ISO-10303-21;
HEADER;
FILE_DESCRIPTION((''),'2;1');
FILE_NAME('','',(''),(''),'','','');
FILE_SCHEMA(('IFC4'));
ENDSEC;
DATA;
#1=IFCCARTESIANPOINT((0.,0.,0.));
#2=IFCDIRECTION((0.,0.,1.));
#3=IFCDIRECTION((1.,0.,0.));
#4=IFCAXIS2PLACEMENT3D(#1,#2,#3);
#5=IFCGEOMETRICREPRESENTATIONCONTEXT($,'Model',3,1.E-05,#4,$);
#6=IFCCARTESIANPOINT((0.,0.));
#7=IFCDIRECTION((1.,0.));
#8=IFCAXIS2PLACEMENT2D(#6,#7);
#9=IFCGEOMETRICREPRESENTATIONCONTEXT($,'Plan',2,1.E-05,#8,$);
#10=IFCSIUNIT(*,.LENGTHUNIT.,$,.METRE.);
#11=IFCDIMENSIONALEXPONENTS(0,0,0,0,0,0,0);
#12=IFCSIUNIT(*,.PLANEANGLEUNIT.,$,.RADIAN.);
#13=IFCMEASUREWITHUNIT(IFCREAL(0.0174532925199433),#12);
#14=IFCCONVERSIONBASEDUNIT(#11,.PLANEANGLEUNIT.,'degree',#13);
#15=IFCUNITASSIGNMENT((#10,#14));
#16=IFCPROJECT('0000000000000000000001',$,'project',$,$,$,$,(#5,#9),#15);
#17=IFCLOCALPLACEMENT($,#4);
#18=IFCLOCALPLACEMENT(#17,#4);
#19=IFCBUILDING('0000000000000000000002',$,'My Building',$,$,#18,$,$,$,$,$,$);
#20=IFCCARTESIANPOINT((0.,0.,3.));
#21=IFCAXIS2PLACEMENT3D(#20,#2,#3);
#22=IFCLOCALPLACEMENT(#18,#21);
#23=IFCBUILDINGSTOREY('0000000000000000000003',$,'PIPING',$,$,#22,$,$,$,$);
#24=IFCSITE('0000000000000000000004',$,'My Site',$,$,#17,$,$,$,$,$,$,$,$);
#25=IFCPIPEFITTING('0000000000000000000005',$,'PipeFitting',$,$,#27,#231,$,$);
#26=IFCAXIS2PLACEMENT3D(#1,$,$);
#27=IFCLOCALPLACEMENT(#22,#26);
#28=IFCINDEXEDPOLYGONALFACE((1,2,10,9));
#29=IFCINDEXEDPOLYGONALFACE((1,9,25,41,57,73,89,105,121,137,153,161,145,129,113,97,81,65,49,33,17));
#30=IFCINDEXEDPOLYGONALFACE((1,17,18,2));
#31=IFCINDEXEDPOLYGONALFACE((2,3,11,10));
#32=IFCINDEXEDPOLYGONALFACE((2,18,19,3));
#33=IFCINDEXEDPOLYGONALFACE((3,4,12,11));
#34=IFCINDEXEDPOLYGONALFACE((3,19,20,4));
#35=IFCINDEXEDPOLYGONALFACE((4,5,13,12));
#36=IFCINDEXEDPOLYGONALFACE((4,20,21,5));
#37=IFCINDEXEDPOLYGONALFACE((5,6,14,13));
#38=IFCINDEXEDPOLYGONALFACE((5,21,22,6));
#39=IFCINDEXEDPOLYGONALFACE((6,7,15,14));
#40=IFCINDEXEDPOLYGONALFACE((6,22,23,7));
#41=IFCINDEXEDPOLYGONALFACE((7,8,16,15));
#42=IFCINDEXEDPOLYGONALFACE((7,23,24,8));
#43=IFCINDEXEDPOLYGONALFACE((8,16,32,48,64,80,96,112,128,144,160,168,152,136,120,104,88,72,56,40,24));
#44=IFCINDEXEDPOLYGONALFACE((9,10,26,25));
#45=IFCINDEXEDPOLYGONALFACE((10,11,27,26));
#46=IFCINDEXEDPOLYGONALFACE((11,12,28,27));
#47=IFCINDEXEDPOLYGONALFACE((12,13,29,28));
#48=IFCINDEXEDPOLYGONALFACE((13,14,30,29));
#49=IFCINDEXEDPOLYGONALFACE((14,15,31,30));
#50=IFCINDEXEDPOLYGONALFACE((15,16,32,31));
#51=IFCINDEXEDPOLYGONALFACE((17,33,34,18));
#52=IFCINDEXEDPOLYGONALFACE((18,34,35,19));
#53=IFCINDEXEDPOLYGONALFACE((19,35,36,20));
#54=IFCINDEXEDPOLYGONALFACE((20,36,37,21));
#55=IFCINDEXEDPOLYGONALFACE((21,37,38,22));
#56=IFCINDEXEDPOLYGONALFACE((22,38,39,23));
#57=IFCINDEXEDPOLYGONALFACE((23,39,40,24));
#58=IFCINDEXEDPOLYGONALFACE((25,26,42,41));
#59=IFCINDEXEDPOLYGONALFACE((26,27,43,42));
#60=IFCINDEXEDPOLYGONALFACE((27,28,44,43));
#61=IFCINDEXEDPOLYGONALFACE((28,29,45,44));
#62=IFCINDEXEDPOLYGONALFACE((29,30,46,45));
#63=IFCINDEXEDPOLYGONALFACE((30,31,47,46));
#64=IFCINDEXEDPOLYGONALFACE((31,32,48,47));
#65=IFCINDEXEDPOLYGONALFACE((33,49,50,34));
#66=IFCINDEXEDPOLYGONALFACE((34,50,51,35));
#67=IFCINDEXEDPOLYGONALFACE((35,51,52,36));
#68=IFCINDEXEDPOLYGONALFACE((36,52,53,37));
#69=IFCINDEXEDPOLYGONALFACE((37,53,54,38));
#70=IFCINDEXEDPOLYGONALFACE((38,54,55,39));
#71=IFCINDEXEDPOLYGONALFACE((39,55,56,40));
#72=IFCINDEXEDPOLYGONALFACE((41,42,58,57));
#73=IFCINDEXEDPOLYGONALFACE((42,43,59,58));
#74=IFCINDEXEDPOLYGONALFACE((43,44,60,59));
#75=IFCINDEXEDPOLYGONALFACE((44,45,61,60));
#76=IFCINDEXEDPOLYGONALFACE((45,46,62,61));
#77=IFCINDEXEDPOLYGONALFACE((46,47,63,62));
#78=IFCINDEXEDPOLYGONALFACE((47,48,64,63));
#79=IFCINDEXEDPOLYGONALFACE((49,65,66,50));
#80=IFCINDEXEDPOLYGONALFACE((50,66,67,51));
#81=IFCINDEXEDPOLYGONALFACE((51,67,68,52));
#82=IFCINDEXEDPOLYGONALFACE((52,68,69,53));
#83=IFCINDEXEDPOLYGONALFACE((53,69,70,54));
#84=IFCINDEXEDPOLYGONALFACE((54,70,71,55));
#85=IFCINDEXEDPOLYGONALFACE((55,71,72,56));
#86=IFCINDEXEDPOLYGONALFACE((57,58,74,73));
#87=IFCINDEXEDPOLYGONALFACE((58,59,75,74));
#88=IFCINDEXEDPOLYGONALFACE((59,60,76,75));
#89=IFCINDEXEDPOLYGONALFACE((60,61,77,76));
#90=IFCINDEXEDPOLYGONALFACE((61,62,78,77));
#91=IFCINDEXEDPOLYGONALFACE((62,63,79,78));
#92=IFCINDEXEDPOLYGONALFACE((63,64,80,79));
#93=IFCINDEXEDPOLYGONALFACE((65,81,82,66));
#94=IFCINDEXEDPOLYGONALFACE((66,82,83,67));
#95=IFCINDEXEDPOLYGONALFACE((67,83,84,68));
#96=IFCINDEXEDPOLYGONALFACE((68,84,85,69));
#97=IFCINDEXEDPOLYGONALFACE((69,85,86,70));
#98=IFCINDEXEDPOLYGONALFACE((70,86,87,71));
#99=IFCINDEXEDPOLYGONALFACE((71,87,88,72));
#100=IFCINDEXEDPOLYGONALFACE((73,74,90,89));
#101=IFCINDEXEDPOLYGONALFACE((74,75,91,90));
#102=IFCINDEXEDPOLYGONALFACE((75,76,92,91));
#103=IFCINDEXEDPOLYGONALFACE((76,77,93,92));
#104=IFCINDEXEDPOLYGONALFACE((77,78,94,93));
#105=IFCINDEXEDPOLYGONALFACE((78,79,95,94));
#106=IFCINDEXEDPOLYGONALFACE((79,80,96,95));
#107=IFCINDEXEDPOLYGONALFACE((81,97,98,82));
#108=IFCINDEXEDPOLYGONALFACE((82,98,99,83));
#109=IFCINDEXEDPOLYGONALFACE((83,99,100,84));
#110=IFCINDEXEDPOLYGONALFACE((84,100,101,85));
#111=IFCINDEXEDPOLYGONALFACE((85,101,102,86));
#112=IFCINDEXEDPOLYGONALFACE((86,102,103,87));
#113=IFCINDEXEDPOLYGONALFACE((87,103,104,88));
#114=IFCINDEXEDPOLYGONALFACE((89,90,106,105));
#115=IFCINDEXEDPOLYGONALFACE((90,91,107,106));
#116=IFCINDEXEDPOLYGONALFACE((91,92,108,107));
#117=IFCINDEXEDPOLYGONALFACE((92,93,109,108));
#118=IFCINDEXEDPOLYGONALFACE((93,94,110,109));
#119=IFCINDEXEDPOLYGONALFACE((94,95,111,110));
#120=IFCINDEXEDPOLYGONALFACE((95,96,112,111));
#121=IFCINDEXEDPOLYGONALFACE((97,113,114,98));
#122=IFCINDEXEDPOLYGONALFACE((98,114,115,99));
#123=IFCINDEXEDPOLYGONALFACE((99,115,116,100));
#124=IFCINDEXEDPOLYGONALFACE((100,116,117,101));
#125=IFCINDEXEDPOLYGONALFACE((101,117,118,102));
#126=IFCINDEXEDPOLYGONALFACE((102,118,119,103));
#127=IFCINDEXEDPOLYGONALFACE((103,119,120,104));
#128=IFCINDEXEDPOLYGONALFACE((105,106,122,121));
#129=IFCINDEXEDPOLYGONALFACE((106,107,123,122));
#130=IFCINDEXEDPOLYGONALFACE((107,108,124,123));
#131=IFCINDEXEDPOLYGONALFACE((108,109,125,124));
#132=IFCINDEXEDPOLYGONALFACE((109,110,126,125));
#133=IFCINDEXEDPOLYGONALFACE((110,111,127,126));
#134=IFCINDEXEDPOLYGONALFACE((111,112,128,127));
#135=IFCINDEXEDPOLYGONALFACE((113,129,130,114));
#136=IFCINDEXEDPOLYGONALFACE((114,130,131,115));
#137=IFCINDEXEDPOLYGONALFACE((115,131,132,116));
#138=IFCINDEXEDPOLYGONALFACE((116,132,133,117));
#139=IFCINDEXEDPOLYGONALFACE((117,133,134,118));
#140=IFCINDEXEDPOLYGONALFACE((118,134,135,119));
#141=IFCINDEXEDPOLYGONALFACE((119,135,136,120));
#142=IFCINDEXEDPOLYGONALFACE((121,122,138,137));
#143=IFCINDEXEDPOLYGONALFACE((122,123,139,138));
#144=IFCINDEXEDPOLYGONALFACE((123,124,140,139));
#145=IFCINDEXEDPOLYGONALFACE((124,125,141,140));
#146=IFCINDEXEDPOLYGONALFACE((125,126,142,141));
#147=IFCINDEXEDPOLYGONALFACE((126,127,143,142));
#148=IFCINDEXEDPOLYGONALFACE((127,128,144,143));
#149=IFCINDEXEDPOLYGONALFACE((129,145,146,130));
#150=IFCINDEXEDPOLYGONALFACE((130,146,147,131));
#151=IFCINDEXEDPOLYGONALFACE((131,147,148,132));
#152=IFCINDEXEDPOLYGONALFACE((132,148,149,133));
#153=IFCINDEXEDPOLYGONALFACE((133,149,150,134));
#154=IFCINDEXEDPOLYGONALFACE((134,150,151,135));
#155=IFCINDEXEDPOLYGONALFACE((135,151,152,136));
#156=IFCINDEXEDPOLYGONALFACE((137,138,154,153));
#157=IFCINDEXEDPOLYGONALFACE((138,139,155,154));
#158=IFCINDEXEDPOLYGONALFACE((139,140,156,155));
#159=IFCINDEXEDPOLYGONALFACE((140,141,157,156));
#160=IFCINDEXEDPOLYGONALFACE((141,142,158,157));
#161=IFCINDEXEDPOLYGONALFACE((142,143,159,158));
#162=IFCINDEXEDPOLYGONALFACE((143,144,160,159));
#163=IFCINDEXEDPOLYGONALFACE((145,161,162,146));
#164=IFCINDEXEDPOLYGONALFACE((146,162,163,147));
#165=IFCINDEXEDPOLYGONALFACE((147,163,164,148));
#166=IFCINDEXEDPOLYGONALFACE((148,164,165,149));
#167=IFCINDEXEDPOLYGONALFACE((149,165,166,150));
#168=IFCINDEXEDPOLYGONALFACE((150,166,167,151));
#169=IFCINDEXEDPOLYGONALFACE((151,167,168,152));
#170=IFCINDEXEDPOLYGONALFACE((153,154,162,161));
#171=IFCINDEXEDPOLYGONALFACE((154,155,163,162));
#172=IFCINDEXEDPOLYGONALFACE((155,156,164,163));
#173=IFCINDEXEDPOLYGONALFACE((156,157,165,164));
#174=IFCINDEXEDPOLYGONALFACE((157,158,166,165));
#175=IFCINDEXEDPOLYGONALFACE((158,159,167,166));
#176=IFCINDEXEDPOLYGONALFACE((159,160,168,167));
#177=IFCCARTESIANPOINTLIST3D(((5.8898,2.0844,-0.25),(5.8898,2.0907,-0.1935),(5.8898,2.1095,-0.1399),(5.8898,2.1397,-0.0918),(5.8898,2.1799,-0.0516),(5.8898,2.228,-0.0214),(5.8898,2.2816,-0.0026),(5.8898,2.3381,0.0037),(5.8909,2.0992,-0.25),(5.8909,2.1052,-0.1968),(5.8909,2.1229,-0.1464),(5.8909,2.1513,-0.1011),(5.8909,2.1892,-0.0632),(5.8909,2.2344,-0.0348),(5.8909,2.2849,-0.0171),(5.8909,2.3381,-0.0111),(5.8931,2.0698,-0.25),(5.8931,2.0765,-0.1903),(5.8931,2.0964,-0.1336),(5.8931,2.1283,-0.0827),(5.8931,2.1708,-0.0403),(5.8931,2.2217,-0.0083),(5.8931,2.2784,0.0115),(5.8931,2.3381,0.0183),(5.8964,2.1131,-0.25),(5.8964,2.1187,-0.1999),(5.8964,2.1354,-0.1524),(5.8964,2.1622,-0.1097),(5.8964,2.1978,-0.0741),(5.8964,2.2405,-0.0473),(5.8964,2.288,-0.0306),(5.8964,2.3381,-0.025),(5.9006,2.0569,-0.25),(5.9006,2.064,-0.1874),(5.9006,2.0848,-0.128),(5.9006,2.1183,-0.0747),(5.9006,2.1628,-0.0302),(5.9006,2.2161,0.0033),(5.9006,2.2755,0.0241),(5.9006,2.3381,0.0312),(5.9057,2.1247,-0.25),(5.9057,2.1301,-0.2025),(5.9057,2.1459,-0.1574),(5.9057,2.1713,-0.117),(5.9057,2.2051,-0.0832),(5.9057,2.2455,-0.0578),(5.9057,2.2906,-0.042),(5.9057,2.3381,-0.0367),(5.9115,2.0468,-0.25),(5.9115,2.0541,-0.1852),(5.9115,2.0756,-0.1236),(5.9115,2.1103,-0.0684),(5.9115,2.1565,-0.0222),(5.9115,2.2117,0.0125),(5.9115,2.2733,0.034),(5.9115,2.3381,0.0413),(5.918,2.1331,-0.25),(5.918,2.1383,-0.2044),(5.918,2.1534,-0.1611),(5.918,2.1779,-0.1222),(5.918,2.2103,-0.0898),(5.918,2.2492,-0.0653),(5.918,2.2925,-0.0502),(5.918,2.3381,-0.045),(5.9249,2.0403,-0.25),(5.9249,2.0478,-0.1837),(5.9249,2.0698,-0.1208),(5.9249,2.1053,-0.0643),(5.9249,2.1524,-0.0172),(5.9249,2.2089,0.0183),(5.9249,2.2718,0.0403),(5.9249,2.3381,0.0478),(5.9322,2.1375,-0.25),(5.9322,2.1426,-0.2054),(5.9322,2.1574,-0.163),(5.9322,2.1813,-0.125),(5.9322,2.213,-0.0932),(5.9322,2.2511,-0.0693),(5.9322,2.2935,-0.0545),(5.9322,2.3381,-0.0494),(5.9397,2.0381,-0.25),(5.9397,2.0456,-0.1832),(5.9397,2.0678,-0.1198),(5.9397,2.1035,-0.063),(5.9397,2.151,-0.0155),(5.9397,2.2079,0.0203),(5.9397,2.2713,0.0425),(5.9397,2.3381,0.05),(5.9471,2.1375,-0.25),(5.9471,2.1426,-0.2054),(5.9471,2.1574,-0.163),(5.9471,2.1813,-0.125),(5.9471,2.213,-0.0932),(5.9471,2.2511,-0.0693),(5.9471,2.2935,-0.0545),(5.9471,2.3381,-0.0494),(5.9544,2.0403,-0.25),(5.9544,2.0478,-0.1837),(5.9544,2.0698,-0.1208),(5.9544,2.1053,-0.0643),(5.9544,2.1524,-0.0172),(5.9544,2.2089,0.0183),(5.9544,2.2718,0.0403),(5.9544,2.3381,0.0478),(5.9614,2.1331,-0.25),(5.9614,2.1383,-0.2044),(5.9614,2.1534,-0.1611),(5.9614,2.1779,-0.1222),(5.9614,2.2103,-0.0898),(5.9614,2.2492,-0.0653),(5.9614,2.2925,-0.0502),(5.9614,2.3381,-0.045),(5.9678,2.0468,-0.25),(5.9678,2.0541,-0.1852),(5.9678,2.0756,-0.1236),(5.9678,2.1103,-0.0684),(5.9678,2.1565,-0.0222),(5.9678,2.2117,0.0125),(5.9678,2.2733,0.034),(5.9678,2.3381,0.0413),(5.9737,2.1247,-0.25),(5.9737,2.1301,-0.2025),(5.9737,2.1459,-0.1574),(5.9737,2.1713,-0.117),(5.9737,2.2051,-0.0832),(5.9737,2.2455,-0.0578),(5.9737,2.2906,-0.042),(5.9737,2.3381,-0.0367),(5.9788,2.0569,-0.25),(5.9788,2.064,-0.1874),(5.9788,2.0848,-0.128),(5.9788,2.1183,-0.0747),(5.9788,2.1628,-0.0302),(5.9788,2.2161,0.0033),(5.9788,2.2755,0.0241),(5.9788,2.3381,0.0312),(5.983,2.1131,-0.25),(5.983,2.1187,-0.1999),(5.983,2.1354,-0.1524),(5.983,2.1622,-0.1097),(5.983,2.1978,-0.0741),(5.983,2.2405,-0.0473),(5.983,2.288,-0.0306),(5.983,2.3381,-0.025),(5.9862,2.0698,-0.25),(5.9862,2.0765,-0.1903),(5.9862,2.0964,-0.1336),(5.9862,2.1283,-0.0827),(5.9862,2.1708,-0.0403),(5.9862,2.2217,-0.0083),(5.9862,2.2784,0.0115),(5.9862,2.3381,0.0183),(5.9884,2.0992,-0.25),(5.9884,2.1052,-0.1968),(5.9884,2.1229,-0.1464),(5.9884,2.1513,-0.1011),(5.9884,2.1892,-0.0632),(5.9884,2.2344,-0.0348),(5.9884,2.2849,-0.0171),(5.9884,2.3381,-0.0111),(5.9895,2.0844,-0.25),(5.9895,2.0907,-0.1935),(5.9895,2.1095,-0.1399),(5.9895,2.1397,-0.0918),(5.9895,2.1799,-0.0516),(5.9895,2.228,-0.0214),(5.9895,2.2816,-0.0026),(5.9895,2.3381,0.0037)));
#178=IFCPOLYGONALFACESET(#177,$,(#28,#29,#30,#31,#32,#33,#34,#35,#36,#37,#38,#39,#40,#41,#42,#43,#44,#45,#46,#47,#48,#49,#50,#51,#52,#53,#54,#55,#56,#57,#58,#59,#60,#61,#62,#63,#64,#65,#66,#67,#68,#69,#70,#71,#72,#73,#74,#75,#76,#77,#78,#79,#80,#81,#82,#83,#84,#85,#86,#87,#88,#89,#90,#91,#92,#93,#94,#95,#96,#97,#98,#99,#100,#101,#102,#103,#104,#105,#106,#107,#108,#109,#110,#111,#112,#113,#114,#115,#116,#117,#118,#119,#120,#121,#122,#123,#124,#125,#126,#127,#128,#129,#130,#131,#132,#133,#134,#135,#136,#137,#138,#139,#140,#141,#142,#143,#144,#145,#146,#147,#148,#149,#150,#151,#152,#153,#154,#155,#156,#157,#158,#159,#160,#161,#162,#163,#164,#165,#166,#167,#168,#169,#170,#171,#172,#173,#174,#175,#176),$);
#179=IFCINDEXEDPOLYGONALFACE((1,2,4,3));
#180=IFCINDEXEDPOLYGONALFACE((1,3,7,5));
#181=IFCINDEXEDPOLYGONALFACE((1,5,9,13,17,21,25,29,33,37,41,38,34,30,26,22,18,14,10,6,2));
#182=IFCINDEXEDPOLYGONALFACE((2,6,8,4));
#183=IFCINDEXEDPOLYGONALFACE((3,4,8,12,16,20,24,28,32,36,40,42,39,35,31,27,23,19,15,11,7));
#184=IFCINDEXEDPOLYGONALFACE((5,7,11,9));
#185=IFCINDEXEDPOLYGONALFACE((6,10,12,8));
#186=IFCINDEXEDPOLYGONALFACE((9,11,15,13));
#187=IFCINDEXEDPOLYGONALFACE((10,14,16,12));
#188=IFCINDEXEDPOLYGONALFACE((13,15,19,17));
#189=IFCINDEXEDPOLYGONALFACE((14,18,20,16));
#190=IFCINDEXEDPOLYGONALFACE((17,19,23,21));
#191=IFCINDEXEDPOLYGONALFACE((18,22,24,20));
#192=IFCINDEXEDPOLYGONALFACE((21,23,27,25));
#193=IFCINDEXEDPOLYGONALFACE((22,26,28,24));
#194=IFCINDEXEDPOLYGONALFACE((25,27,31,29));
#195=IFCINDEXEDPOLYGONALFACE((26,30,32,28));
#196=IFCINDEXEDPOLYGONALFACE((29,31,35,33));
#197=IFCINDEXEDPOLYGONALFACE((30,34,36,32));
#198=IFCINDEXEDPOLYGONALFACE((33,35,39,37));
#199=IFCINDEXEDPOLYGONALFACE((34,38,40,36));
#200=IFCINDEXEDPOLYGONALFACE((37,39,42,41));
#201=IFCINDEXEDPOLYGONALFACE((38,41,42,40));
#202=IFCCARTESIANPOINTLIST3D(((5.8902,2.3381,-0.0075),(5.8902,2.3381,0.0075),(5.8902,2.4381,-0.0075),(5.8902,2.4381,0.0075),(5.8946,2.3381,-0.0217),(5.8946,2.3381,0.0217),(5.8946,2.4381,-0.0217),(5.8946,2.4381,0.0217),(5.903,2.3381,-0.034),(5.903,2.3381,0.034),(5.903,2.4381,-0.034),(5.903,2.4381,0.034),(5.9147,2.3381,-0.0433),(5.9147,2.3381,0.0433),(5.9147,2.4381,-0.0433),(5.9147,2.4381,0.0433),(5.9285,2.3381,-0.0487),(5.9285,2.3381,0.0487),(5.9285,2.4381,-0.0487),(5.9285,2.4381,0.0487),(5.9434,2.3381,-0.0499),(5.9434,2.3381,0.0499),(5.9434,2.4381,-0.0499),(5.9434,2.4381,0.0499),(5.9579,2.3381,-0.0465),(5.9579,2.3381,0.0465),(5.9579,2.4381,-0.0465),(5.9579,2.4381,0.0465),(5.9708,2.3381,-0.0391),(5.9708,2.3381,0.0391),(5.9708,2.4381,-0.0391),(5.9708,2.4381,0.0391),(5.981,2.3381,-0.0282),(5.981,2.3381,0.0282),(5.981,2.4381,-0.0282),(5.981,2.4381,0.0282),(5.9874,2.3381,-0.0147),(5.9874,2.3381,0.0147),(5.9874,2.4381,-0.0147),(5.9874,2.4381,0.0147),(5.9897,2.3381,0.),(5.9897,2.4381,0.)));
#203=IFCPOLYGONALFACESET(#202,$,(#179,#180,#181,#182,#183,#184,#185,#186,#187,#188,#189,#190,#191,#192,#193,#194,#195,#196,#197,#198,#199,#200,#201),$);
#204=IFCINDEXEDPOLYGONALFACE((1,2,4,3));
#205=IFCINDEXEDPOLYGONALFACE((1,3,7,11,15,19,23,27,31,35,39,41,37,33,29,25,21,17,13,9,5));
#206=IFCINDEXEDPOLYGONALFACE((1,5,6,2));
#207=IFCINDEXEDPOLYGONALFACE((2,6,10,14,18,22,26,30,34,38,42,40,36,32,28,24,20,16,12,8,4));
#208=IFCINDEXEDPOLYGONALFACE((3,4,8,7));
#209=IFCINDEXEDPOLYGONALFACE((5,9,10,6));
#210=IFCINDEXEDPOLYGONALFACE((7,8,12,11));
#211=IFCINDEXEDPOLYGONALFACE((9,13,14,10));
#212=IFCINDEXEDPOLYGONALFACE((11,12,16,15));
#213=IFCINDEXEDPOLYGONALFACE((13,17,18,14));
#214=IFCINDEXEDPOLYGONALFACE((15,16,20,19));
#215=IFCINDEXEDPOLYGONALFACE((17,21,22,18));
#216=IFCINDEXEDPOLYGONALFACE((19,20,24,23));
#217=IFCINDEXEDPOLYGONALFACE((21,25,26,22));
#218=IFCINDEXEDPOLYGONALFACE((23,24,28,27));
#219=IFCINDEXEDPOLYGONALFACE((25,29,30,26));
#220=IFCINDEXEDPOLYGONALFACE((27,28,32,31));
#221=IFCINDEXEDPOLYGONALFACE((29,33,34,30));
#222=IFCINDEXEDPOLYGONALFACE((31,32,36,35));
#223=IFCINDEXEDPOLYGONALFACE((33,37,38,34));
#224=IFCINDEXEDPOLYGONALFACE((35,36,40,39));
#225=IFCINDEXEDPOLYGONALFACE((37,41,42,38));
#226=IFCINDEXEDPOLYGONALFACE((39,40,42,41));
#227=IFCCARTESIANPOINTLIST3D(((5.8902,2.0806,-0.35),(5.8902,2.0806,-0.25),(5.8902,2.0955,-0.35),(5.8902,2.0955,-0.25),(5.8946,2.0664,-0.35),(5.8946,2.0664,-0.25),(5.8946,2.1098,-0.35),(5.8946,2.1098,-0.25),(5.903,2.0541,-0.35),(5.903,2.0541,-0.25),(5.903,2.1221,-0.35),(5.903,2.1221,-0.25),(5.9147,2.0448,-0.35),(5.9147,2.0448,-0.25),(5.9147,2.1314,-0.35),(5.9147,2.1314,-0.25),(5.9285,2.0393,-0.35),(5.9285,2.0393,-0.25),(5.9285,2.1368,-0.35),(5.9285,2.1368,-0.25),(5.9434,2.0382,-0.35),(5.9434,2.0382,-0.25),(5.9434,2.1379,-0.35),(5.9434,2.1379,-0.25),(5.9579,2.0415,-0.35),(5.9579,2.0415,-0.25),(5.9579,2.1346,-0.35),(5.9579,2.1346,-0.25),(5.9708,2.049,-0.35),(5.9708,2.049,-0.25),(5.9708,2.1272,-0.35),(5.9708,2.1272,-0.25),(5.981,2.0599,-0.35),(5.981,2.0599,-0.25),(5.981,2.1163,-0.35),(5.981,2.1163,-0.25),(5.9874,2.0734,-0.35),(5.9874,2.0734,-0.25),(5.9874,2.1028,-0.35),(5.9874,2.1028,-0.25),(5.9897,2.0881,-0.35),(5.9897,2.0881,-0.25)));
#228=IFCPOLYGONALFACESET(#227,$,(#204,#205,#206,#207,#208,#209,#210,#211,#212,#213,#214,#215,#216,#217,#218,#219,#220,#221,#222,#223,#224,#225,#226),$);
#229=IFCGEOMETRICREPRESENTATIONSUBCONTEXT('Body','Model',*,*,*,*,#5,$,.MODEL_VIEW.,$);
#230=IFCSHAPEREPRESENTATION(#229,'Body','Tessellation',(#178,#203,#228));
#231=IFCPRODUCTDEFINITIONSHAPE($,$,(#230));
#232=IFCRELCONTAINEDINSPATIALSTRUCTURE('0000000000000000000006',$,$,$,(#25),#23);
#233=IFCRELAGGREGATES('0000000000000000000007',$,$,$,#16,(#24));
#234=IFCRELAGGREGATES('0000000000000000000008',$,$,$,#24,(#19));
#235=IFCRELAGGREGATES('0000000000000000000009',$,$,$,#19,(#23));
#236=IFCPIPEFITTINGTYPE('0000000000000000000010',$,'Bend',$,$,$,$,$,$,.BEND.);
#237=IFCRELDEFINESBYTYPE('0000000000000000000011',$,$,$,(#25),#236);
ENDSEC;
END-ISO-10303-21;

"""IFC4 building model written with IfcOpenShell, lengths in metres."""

from ifc_helpers import new_model, entity, si_unit, converted_unit, frame, origin_with_axes, origin_2d_with_axis, place, context, subcontext, project, spatial, circle, extrude, source, transform, mapped, type_object, type_shapes, element, save


model = new_model("IFC4")

# Units and contexts
model_context = context("Model", 3, precision=1e-05, world=origin_with_axes())
plan_context = context("Plan", 2, precision=1e-05, world=origin_2d_with_axis())
body_context = subcontext(model_context, "Body", "Model", "MODEL_VIEW")
ifc_project = project(units=[si_unit("LENGTHUNIT", "METRE"), converted_unit("PLANEANGLEUNIT", "degree", entity("IfcReal", 0.0174532925199433), si_unit("PLANEANGLEUNIT", "RADIAN"), dimensions=[0, 0, 0, 0, 0, 0, 0])], contexts=[model_context, plan_context])

# Site, building, storey
site_placement = place(None, origin_with_axes())
site = spatial("IfcSite", under=ifc_project, at=site_placement, Name="My Site")
building_placement = place(site_placement, origin_with_axes())
building = spatial("IfcBuilding", under=site, at=building_placement, Name="My Building")
storey_placement = place(building_placement, frame((0.0, 0.0, 3.0), z_axis=(0.0, 0.0, 1.0), x_axis=(1.0, 0.0, 0.0)))
storey = spatial("IfcBuildingStorey", under=building, at=storey_placement, Name="PIPING")

# Pipe fitting
pipe_fitting_type = type_object("IfcPipeFittingType", Name="Bend", PredefinedType="BEND")
shared_shape = source(origin_with_axes(), body_context, "Body", "SolidModel", [
    entity("IfcSweptDiskSolid", entity("IfcIndexedPolyCurve", entity("IfcCartesianPointList3D", [[0.0, 0.0, 0.1], [0.0, -0.0732, 0.2768], [0.0, -0.25, 0.35]]), [entity("IfcArcIndex", [1, 2, 3])]), 0.05),
    extrude(circle(Radius=0.05), origin_with_axes(), (0.0, 0.0, 1.0), 0.1),
    extrude(circle(Radius=0.05), frame((0.0, -0.25, 0.35), z_axis=(0.0, -1.0, 0.0), x_axis=(1.0, 0.0, 0.0)), (0.0, 0.0, 1.0), 0.1),
])
type_shapes(pipe_fitting_type, [shared_shape])
for number, where, z_axis, x_axis, name in (
    (1, (5.9397, 2.4381, 0.0), (0.0, -1.0, 0.0), (1.0, 0.0, 0.0), "PipeFitting"),
):
    element("IfcPipeFitting", number, at=place(storey_placement, frame(where, z_axis=z_axis, x_axis=x_axis)), inside=storey, type_object=pipe_fitting_type, Name=name, context=body_context, shape_type="MappedRepresentation", body=[
        mapped(shared_shape, transform((0.0, 0.0, 0.0), x_axis=(1.0, 0.0, 0.0), y_axis=(0.0, 1.0, 0.0), z_axis=(0.0, 0.0, 1.0), scale=1.0)),
    ])

save(model, "model.ifc")
